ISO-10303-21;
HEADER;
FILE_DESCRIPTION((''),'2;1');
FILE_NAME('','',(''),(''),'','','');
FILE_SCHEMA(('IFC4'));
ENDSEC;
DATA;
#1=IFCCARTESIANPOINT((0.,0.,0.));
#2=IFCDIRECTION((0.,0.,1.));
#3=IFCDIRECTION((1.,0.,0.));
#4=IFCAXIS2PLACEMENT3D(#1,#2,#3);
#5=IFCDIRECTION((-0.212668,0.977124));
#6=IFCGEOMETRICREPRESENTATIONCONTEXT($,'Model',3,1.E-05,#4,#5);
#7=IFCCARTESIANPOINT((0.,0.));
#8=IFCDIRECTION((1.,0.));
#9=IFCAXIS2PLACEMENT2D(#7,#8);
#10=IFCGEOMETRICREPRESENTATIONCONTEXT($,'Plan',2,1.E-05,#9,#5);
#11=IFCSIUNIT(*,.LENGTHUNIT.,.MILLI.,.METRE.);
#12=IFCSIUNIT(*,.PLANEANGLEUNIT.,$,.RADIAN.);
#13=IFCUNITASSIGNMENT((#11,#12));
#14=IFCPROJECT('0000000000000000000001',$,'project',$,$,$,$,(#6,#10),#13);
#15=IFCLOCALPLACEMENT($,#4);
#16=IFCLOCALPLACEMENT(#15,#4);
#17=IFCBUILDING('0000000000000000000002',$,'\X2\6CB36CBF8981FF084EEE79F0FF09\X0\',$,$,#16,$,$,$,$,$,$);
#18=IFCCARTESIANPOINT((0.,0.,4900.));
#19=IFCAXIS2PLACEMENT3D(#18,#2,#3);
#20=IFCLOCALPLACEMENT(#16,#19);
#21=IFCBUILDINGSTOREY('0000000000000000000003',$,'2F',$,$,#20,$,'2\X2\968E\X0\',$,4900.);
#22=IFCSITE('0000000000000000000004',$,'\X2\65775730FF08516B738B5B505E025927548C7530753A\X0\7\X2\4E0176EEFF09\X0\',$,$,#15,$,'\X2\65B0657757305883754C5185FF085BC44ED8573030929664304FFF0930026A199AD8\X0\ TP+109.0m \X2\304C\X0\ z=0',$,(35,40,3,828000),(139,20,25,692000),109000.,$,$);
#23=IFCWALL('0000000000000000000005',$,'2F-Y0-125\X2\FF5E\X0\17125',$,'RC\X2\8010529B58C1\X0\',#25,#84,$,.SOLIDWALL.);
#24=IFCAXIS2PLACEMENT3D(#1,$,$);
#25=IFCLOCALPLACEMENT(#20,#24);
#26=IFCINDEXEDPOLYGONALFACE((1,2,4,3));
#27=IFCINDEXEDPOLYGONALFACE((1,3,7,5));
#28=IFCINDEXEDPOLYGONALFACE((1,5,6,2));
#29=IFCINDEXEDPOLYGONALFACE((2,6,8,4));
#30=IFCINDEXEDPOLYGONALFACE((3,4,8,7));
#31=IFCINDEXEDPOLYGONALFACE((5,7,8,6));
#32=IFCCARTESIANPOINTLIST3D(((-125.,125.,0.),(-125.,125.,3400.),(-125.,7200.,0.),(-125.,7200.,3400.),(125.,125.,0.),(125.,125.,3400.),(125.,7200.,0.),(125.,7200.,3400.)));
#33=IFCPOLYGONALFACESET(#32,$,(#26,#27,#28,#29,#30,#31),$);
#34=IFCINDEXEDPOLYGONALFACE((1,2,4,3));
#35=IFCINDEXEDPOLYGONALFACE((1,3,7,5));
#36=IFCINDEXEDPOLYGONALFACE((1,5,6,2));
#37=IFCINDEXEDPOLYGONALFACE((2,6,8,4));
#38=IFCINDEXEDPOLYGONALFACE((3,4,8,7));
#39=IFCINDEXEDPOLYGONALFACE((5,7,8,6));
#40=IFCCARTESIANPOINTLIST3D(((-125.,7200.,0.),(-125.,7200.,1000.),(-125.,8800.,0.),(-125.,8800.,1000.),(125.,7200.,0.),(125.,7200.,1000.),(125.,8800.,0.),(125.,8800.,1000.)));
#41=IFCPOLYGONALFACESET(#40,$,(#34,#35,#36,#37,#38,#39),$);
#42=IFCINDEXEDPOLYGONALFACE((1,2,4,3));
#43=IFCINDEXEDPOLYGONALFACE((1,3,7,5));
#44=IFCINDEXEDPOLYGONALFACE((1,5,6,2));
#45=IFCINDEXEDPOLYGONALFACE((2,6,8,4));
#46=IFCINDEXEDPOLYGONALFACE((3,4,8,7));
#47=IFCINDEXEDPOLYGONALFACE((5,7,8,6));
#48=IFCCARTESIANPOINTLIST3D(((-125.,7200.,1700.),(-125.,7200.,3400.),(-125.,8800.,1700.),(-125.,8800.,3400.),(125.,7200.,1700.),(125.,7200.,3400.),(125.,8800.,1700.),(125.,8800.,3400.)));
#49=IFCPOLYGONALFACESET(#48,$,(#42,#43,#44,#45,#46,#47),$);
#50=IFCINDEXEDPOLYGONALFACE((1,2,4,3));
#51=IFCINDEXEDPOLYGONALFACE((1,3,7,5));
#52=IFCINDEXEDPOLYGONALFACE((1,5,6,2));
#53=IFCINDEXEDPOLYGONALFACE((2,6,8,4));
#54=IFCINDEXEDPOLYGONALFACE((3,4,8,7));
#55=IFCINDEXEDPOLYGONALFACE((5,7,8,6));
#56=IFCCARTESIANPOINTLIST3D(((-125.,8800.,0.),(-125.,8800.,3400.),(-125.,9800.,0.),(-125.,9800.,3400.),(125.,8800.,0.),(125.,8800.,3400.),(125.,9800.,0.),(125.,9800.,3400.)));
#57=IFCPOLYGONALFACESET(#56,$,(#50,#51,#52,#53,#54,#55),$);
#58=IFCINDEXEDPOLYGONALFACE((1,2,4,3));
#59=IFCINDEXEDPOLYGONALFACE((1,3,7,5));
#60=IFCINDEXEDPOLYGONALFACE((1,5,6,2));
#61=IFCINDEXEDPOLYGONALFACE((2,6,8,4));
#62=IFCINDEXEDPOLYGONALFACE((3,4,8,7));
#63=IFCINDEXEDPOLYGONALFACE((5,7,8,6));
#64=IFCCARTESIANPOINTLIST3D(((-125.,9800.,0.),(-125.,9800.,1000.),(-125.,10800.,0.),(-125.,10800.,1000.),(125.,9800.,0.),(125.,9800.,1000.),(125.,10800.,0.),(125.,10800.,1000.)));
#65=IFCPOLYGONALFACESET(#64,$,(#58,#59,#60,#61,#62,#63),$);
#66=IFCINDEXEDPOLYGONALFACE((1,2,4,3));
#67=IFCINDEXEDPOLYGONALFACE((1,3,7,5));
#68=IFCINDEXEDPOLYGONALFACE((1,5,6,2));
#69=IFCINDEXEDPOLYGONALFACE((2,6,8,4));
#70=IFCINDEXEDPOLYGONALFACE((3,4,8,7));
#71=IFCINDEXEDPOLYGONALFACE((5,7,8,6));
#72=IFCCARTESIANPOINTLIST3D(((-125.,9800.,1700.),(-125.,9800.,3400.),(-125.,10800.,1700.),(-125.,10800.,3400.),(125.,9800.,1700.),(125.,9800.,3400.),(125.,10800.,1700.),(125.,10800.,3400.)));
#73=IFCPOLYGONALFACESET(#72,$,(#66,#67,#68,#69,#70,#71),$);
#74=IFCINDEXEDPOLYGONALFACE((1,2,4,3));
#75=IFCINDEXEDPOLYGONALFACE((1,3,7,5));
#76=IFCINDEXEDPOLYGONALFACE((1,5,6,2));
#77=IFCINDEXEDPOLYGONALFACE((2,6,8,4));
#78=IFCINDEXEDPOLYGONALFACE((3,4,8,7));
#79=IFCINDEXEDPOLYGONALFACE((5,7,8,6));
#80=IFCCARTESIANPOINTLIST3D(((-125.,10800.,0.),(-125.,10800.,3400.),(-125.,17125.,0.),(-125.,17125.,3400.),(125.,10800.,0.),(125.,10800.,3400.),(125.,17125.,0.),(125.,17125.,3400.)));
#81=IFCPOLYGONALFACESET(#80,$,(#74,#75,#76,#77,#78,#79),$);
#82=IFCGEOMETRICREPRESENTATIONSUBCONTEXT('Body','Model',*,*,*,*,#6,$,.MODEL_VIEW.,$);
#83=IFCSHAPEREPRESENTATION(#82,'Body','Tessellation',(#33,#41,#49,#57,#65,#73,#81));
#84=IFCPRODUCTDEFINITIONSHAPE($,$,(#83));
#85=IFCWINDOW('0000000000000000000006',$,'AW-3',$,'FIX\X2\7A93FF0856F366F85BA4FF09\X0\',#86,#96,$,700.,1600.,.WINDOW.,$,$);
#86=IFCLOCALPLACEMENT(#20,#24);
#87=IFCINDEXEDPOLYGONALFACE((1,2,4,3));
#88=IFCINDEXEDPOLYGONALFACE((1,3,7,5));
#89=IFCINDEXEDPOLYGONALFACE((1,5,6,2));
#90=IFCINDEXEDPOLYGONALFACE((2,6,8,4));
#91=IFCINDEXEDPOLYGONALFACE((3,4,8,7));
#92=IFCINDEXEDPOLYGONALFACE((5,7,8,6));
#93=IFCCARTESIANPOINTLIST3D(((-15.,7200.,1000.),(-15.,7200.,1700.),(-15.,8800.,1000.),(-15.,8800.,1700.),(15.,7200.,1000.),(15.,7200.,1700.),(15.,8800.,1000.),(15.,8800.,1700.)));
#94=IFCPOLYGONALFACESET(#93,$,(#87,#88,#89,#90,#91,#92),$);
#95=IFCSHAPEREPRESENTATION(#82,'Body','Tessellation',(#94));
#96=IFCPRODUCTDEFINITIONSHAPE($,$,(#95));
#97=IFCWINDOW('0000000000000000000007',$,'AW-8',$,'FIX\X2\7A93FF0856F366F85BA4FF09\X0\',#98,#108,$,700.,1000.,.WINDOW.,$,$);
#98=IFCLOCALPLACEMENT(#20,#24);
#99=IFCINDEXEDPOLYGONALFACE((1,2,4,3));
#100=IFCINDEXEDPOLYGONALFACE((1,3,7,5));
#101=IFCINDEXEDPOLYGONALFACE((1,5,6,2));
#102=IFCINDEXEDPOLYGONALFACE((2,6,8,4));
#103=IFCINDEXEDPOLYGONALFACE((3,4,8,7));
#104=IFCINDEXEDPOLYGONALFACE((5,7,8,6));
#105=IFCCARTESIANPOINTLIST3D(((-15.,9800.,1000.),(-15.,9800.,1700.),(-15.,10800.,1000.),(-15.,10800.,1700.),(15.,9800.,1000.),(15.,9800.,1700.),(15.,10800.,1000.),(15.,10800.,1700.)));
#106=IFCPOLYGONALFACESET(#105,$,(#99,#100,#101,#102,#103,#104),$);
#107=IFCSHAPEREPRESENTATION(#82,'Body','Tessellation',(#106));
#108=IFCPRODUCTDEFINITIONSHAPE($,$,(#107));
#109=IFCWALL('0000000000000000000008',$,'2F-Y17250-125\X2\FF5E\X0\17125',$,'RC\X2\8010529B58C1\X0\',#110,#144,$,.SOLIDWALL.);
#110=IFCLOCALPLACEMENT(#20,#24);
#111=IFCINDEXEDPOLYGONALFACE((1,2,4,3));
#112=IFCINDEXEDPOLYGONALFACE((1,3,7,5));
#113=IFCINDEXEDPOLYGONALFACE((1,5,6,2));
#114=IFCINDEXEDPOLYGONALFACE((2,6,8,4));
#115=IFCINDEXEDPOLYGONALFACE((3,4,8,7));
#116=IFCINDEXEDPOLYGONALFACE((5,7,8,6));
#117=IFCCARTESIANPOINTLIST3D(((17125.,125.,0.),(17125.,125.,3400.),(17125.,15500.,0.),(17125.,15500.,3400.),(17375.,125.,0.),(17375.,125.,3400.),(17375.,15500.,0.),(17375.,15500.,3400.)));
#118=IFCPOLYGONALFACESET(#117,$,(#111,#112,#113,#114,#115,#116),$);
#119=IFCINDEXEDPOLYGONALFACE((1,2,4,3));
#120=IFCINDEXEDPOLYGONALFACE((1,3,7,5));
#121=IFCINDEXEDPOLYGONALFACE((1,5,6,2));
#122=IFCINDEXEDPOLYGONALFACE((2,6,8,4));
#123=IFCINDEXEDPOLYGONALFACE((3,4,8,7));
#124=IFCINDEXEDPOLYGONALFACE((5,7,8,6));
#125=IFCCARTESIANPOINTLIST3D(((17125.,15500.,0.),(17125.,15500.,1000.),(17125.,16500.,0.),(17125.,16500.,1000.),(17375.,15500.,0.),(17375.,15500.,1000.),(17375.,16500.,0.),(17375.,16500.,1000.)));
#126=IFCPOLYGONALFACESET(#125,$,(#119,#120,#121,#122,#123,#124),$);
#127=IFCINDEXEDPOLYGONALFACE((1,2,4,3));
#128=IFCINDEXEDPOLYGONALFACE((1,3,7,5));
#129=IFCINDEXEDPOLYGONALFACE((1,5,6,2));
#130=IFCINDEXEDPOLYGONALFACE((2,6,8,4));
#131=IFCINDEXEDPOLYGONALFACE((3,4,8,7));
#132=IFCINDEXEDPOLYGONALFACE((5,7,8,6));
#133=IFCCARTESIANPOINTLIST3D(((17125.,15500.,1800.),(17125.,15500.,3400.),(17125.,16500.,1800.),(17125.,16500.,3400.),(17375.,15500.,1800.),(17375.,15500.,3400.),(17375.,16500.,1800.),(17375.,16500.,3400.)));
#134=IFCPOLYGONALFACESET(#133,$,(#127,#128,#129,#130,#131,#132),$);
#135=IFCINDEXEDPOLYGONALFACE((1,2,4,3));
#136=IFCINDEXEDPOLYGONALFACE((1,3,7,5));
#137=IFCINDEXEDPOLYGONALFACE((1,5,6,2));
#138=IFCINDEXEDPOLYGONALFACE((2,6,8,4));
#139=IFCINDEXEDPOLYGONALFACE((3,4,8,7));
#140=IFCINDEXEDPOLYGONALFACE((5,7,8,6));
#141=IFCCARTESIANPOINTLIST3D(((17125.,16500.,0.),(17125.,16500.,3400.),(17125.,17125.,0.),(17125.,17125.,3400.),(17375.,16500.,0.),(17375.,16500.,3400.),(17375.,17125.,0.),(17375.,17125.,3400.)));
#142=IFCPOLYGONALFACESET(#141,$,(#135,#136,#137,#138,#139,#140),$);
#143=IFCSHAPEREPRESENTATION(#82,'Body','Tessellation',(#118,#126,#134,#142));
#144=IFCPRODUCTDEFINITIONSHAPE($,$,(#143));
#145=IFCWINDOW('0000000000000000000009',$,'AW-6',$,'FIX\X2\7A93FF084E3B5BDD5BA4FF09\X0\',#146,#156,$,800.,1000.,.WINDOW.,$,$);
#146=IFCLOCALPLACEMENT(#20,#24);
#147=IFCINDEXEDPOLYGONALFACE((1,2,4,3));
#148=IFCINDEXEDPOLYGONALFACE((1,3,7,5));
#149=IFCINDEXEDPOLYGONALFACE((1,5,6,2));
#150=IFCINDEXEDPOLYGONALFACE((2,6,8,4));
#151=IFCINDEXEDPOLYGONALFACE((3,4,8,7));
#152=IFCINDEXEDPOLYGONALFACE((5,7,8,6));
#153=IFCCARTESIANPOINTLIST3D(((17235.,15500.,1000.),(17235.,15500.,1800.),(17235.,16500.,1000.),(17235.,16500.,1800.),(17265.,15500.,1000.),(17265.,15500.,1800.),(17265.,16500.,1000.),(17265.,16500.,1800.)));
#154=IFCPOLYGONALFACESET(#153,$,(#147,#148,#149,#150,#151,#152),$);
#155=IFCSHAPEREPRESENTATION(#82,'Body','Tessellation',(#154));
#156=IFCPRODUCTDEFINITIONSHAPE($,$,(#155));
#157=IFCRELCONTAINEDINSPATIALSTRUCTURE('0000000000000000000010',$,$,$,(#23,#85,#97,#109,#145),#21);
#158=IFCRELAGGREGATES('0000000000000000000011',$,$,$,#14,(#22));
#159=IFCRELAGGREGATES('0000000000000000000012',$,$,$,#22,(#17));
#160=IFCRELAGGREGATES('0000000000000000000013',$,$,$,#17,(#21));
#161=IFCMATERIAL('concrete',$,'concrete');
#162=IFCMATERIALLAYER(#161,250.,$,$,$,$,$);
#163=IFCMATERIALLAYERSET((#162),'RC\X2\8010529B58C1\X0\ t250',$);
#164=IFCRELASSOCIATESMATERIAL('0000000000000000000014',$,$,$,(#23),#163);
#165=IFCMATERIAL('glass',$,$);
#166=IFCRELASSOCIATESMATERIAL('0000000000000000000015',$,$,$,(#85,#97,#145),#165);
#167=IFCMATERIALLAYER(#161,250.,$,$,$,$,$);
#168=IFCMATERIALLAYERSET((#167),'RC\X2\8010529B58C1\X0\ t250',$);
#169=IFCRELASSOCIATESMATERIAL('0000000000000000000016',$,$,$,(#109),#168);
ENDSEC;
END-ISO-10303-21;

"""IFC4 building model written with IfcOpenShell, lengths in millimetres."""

from ifc_helpers import new_model, si_unit, direction, frame, frame_2d, origin, origin_with_axes, origin_2d_with_axis, place, context, subcontext, project, spatial, rectangle, extrude, material, layer, layer_set, layer_usage, element, fill, save


model = new_model("IFC4")

# Units and contexts
model_context = context("Model", 3, precision=1e-05, world=origin_with_axes(), true_north=direction((-0.212668, 0.977124)))
plan_context = context("Plan", 2, precision=1e-05, world=origin_2d_with_axis(), true_north=direction((-0.212668, 0.977124)))
body_context = subcontext(model_context, "Body", "Model", "MODEL_VIEW")
ifc_project = project(units=[si_unit("LENGTHUNIT", "METRE", prefix="MILLI"), si_unit("PLANEANGLEUNIT", "RADIAN")], contexts=[model_context, plan_context])

# Site, building, storey
site_placement = place(None, origin_with_axes())
site = spatial("IfcSite", under=ifc_project, at=site_placement, Name="敷地（八王子市大和田町7丁目）", LongName="新敷地境界内（寄付地を除く）。標高 TP+109.0m が z=0", RefLatitude=(35, 40, 3, 828000), RefLongitude=(139, 20, 25, 692000), RefElevation=109000.0)
building_placement = place(site_placement, origin_with_axes())
building = spatial("IfcBuilding", under=site, at=building_placement, Name="河沿要（仮称）")
storey_placement = place(building_placement, frame((0.0, 0.0, 4900.0), z_axis=(0.0, 0.0, 1.0), x_axis=(1.0, 0.0, 0.0)))
storey = spatial("IfcBuildingStorey", under=building, at=storey_placement, Name="2F", LongName="2階", Elevation=4900.0)

# Shared definitions
ifc_material_1 = material(Name="concrete", Category="concrete")
ifc_material_2 = material(Name="glass")

# Wall, openings, windows
ifc_layer_1 = layer(ifc_material_1, 250.0)
ifc_layer_set_1 = layer_set([ifc_layer_1], Name="RC耐力壁 t250")
ifc_layer_usage_1 = layer_usage(ifc_layer_set_1, "AXIS2", "POSITIVE", 0.0)
wall_1_placement = place(storey_placement, origin_with_axes())
wall_1 = element("IfcWall", 1, at=wall_1_placement, inside=storey, material=ifc_layer_usage_1, Name="2F-Y0-125～17125", ObjectType="RC耐力壁", PredefinedType="SOLIDWALL", context=body_context, shape_type="SweptSolid", body=[
    extrude(rectangle(XDim=250.0, YDim=7075.0, at=frame_2d((0.0, 3662.5))), origin(), (0.0, 0.0, 1.0), 3400.0),
    extrude(rectangle(XDim=250.0, YDim=1600.0, at=frame_2d((0.0, 8000.0))), origin(), (0.0, 0.0, 1.0), 1000.0),
    extrude(rectangle(XDim=250.0, YDim=1600.0, at=frame_2d((0.0, 8000.0))), frame((0.0, 0.0, 1700.0)), (0.0, 0.0, 1.0), 1700.0),
    extrude(rectangle(XDim=250.0, YDim=1000.0, at=frame_2d((0.0, 9300.0))), origin(), (0.0, 0.0, 1.0), 3400.0),
    extrude(rectangle(XDim=250.0, YDim=1000.0, at=frame_2d((0.0, 10300.0))), origin(), (0.0, 0.0, 1.0), 1000.0),
    extrude(rectangle(XDim=250.0, YDim=1000.0, at=frame_2d((0.0, 10300.0))), frame((0.0, 0.0, 1700.0)), (0.0, 0.0, 1.0), 1700.0),
    extrude(rectangle(XDim=250.0, YDim=6325.0, at=frame_2d((0.0, 13962.5))), origin(), (0.0, 0.0, 1.0), 3400.0),
])
opening_1_placement = place(storey_placement, origin_with_axes())
opening_1 = element("IfcOpeningElement", 2, at=opening_1_placement, inside=storey, cuts=wall_1, PredefinedType="OPENING", context=body_context, shape_type="SweptSolid", body=[
    extrude(rectangle(XDim=300.0, YDim=1600.0, at=frame_2d((0.0, 8000.0))), frame((0.0, 0.0, 1000.0)), (0.0, 0.0, 1.0), 700.0),
])
opening_2_placement = place(storey_placement, origin_with_axes())
opening_2 = element("IfcOpeningElement", 3, at=opening_2_placement, inside=storey, cuts=wall_1, PredefinedType="OPENING", context=body_context, shape_type="SweptSolid", body=[
    extrude(rectangle(XDim=300.0, YDim=1000.0, at=frame_2d((0.0, 10300.0))), frame((0.0, 0.0, 1000.0)), (0.0, 0.0, 1.0), 700.0),
])
window_1_placement = place(storey_placement, origin_with_axes())
window_1 = element("IfcWindow", 4, at=window_1_placement, inside=storey, material=ifc_material_2, Name="AW-3", ObjectType="FIX窓（図書室）", OverallHeight=700.0, OverallWidth=1600.0, PredefinedType="WINDOW", context=body_context, shape_type="SweptSolid", body=[
    extrude(rectangle(XDim=30.0, YDim=1600.0, at=frame_2d((0.0, 8000.0))), frame((0.0, 0.0, 1000.0)), (0.0, 0.0, 1.0), 700.0),
])
fill(opening_1, window_1)
window_2_placement = place(storey_placement, origin_with_axes())
window_2 = element("IfcWindow", 5, at=window_2_placement, inside=storey, material=ifc_material_2, Name="AW-8", ObjectType="FIX窓（図書室）", OverallHeight=700.0, OverallWidth=1000.0, PredefinedType="WINDOW", context=body_context, shape_type="SweptSolid", body=[
    extrude(rectangle(XDim=30.0, YDim=1000.0, at=frame_2d((0.0, 10300.0))), frame((0.0, 0.0, 1000.0)), (0.0, 0.0, 1.0), 700.0),
])
fill(opening_2, window_2)

# Wall, opening, window
ifc_layer_2 = layer(ifc_material_1, 250.0)
ifc_layer_set_2 = layer_set([ifc_layer_2], Name="RC耐力壁 t250")
ifc_layer_usage_2 = layer_usage(ifc_layer_set_2, "AXIS2", "POSITIVE", 0.0)
wall_2_placement = place(storey_placement, origin_with_axes())
wall_2 = element("IfcWall", 6, at=wall_2_placement, inside=storey, material=ifc_layer_usage_2, Name="2F-Y17250-125～17125", ObjectType="RC耐力壁", PredefinedType="SOLIDWALL", context=body_context, shape_type="SweptSolid", body=[
    extrude(rectangle(XDim=250.0, YDim=15375.0, at=frame_2d((17250.0, 7812.5))), origin(), (0.0, 0.0, 1.0), 3400.0),
    extrude(rectangle(XDim=250.0, YDim=1000.0, at=frame_2d((17250.0, 16000.0))), origin(), (0.0, 0.0, 1.0), 1000.0),
    extrude(rectangle(XDim=250.0, YDim=1000.0, at=frame_2d((17250.0, 16000.0))), frame((0.0, 0.0, 1800.0)), (0.0, 0.0, 1.0), 1600.0),
    extrude(rectangle(XDim=250.0, YDim=625.0, at=frame_2d((17250.0, 16812.5))), origin(), (0.0, 0.0, 1.0), 3400.0),
])
opening_3_placement = place(storey_placement, origin_with_axes())
opening_3 = element("IfcOpeningElement", 7, at=opening_3_placement, inside=storey, cuts=wall_2, PredefinedType="OPENING", context=body_context, shape_type="SweptSolid", body=[
    extrude(rectangle(XDim=300.0, YDim=1000.0, at=frame_2d((17250.0, 16000.0))), frame((0.0, 0.0, 1000.0)), (0.0, 0.0, 1.0), 800.0),
])
window_3_placement = place(storey_placement, origin_with_axes())
window_3 = element("IfcWindow", 8, at=window_3_placement, inside=storey, material=ifc_material_2, Name="AW-6", ObjectType="FIX窓（主寝室）", OverallHeight=800.0, OverallWidth=1000.0, PredefinedType="WINDOW", context=body_context, shape_type="SweptSolid", body=[
    extrude(rectangle(XDim=30.0, YDim=1000.0, at=frame_2d((17250.0, 16000.0))), frame((0.0, 0.0, 1000.0)), (0.0, 0.0, 1.0), 800.0),
])
fill(opening_3, window_3)

save(model, "model.ifc")
